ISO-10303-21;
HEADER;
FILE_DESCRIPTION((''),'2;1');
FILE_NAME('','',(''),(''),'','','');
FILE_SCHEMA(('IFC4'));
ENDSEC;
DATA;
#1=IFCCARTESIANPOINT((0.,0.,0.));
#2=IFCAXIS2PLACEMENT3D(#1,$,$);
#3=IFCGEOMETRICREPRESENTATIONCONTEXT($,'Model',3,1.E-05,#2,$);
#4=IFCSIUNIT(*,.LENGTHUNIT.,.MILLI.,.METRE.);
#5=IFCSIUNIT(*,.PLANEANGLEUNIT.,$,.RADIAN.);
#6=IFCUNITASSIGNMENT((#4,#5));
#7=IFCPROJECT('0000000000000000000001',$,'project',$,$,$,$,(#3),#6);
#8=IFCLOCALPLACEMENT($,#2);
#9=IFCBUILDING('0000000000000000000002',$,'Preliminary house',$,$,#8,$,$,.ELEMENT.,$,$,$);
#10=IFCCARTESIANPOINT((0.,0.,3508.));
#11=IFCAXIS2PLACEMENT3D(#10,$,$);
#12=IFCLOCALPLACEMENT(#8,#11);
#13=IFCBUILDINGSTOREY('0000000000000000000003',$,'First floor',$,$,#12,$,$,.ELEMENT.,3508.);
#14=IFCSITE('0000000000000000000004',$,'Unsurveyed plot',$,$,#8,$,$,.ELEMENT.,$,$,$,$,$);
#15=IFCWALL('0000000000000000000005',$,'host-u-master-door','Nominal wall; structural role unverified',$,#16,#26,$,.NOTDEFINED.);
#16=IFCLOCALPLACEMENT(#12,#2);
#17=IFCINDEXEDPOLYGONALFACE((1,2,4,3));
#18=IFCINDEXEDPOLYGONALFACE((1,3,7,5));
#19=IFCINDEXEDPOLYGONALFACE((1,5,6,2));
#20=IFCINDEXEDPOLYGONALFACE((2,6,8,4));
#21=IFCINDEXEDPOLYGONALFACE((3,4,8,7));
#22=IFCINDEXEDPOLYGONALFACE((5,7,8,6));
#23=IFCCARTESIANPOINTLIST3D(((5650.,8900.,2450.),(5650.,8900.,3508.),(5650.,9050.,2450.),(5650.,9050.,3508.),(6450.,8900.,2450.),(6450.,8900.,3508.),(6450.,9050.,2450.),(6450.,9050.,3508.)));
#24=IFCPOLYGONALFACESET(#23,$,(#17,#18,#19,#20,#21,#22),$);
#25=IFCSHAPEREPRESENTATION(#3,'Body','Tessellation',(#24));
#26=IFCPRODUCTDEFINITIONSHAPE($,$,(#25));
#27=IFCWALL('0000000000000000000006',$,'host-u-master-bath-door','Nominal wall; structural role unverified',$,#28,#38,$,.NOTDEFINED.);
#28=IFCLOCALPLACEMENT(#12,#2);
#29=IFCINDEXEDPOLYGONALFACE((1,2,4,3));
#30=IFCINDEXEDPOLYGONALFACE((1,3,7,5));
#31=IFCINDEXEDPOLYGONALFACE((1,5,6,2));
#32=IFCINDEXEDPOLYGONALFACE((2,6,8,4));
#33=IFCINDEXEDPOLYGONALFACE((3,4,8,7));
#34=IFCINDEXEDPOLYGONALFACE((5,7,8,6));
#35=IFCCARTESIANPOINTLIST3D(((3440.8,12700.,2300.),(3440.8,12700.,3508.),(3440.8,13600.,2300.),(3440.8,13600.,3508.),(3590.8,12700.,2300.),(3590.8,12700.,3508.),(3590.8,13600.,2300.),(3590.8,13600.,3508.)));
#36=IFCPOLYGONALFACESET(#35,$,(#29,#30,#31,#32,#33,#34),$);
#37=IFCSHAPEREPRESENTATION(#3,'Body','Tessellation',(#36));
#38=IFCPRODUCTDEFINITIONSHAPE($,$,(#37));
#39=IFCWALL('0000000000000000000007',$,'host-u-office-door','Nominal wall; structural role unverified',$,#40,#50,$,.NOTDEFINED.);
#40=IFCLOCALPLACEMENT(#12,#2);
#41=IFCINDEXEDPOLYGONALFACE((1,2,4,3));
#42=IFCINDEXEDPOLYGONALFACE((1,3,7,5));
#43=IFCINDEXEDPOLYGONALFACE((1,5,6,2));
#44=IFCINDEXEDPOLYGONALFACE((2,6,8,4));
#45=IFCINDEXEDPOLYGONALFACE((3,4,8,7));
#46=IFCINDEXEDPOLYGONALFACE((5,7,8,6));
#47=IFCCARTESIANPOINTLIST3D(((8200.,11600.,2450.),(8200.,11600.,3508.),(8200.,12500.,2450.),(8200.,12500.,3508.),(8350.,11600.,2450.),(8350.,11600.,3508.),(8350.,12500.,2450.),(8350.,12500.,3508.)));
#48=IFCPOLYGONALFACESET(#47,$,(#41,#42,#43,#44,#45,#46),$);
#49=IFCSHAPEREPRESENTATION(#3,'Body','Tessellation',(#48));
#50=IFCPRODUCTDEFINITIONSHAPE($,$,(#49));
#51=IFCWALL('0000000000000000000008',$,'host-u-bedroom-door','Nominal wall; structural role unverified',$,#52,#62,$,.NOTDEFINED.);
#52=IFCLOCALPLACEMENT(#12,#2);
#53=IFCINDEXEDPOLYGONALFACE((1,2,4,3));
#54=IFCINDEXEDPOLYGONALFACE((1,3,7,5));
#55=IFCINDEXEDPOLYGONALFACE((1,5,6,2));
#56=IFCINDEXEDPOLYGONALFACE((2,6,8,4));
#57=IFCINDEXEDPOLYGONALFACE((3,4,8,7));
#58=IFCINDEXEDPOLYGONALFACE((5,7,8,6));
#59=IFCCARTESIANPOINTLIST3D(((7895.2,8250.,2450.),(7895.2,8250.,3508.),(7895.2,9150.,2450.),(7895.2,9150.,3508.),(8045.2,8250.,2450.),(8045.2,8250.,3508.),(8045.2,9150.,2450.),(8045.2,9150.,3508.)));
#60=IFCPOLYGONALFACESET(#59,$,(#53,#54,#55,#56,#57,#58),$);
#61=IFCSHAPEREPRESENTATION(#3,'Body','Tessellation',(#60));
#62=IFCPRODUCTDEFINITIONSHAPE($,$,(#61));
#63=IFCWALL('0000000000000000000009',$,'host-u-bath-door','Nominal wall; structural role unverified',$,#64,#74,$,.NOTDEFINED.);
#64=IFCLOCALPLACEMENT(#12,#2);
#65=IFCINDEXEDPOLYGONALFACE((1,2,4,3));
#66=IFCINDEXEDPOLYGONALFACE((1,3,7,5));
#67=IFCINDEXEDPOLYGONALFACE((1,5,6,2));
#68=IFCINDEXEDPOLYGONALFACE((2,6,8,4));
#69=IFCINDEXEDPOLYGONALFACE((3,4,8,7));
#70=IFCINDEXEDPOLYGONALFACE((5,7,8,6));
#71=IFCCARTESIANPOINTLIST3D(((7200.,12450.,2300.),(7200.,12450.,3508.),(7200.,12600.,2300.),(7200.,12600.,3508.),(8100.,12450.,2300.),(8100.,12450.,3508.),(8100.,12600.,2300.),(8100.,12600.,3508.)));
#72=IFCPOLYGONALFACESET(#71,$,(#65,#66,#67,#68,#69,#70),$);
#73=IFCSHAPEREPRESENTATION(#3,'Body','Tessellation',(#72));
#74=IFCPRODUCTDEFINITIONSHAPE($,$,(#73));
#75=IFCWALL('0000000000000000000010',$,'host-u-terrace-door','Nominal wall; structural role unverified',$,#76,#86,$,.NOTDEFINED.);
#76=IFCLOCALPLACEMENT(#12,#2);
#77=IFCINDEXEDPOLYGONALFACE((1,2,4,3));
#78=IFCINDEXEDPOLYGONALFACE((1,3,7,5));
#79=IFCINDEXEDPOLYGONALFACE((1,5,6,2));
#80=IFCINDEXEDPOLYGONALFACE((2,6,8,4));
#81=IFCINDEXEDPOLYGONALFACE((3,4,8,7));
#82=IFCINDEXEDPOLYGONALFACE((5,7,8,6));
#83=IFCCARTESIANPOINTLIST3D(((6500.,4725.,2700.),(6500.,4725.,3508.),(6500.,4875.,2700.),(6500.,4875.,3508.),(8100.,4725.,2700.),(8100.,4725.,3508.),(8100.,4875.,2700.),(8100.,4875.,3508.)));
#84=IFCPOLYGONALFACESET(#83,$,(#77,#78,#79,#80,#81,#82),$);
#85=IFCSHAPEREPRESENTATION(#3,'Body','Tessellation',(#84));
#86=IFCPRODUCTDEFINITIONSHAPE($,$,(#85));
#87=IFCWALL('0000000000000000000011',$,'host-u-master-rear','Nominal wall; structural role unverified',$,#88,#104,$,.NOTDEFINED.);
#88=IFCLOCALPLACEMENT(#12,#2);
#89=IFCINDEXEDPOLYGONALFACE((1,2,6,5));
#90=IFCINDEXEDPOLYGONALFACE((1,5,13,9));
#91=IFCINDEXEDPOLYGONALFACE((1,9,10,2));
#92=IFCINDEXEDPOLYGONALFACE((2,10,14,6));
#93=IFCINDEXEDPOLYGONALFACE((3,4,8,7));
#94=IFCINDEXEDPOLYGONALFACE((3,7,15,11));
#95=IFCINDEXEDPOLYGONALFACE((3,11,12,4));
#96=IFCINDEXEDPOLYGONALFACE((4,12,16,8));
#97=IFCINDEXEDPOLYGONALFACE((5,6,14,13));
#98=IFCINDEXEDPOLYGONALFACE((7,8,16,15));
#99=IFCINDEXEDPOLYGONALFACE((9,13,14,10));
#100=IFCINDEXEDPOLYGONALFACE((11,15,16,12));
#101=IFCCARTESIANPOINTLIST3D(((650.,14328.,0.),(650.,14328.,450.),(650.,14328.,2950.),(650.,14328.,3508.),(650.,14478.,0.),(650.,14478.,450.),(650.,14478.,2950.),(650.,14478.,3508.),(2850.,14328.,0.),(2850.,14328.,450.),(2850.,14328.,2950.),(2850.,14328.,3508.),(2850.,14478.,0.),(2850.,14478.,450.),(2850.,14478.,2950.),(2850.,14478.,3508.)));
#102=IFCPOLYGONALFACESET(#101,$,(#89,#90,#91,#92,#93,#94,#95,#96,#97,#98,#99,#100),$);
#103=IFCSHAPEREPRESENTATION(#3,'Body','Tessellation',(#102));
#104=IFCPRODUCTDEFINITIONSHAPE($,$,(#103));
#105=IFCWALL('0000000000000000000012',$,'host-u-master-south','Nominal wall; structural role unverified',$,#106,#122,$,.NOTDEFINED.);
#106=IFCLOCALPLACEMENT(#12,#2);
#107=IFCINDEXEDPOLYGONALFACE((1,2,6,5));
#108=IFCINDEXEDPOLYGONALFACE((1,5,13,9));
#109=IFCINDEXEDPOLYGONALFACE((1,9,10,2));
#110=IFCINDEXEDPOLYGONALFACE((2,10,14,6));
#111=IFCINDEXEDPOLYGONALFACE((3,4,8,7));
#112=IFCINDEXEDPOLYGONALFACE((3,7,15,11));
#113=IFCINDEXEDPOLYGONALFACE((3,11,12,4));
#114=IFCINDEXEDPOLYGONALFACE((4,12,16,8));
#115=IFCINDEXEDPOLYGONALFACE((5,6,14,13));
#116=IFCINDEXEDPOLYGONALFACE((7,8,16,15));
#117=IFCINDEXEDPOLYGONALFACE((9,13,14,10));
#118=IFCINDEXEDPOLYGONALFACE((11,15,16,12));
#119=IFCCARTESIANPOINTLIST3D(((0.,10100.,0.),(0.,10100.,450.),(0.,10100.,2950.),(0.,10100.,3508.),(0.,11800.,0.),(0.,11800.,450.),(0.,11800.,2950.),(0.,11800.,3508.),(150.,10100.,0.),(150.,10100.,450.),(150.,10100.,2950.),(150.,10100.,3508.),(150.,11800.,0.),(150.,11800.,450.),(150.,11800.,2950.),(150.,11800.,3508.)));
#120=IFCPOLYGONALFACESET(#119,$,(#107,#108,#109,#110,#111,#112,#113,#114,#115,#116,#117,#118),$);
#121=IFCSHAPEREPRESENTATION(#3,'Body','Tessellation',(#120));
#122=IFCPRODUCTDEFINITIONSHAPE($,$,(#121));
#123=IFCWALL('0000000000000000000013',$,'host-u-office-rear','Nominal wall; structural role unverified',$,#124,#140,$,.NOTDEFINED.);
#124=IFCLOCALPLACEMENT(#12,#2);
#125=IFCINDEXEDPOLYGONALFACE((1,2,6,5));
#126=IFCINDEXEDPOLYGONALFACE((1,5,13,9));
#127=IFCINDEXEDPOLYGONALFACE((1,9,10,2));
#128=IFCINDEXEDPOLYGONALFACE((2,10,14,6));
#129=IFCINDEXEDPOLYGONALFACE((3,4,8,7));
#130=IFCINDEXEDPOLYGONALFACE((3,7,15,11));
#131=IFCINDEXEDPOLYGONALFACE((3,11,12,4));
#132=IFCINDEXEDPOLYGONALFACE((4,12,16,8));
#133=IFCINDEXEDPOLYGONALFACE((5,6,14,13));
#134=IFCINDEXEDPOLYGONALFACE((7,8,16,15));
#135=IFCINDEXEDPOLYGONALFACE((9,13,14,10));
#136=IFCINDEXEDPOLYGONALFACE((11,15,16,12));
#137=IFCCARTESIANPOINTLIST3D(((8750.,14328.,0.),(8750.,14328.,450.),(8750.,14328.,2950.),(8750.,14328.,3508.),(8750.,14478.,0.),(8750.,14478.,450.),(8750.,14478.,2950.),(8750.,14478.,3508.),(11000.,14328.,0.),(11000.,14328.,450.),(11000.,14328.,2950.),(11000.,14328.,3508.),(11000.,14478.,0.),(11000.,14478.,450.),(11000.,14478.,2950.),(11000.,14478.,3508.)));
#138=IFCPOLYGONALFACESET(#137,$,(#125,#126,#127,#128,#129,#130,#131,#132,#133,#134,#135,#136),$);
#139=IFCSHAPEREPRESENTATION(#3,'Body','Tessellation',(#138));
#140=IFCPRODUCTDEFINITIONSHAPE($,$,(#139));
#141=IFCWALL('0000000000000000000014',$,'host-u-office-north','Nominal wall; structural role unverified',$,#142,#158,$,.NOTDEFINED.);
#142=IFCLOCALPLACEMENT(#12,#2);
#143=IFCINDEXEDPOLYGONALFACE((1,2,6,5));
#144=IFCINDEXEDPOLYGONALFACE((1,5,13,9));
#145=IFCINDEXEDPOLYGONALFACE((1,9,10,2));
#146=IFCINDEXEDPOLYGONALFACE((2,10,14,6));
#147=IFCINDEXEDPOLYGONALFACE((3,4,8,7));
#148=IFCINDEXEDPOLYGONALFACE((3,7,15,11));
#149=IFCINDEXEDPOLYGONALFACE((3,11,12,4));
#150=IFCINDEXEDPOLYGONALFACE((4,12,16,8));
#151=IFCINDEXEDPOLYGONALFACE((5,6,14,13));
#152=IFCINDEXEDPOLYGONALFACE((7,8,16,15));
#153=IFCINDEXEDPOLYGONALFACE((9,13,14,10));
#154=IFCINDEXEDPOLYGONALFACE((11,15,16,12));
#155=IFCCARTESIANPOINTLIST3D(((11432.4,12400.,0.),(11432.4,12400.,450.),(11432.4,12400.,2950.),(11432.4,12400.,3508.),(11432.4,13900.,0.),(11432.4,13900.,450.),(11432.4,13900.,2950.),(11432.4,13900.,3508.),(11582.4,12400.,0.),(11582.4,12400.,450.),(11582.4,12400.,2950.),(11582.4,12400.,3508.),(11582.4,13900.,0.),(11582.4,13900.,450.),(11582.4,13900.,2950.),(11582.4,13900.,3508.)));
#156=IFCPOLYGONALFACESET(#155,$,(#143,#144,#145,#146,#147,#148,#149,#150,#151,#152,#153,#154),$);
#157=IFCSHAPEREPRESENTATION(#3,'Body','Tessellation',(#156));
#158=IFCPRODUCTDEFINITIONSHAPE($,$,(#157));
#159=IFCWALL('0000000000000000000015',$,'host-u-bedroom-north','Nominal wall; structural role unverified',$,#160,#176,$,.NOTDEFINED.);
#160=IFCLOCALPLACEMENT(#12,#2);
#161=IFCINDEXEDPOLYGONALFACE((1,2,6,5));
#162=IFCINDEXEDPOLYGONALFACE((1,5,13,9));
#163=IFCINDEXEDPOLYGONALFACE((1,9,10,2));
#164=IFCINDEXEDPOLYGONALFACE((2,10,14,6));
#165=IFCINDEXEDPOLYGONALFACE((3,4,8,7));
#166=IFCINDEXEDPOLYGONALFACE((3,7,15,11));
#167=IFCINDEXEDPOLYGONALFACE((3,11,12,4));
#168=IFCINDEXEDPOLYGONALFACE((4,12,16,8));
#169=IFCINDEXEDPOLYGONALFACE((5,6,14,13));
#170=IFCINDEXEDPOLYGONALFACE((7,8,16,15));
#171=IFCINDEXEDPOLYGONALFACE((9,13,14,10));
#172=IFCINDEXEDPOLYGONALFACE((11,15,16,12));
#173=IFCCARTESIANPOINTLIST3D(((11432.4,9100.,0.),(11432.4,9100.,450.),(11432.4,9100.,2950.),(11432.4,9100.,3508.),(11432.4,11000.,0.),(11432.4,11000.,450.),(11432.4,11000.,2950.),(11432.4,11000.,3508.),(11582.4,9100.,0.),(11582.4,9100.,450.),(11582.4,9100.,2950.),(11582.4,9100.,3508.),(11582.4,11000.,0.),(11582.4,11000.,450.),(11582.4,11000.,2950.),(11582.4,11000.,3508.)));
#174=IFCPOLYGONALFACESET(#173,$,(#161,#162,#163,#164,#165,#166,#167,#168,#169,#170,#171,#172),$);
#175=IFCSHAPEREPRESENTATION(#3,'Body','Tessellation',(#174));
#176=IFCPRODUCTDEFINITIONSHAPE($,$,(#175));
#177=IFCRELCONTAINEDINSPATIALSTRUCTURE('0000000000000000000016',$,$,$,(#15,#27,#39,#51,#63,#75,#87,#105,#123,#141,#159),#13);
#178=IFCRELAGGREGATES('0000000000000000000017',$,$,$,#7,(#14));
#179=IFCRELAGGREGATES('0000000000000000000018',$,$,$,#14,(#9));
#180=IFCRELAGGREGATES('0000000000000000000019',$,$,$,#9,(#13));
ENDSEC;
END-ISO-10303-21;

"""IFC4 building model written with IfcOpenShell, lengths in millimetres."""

from ifc_helpers import new_model, si_unit, frame, origin, place, context, project, spatial, polyline, outline, extrude, element, save


model = new_model("IFC4")

# Units and contexts
model_context = context("Model", 3, precision=1e-05, world=origin())
ifc_project = project(units=[si_unit("LENGTHUNIT", "METRE", prefix="MILLI"), si_unit("PLANEANGLEUNIT", "RADIAN")], contexts=[model_context])

# Site, building, storey
placement_1 = place(None, origin())
site = spatial("IfcSite", under=ifc_project, at=placement_1, Name="Unsurveyed plot", CompositionType="ELEMENT")
building = spatial("IfcBuilding", under=site, at=placement_1, Name="Preliminary house", CompositionType="ELEMENT")
placement_2 = place(placement_1, frame((0.0, 0.0, 3508.0)))
storey = spatial("IfcBuildingStorey", under=building, at=placement_2, Name="First floor", CompositionType="ELEMENT", Elevation=3508.0)

# Walls, openings
wall_1 = element("IfcWall", 1, at=placement_2, inside=storey, Name="host-u-master-door", Description="Nominal wall; structural role unverified", PredefinedType="NOTDEFINED", context=model_context, shape_type="SweptSolid", body=[
    extrude(outline(polyline([(6450.0, 9050.0), (6450.0, 8900.0), (5650.0, 8900.0), (5650.0, 9050.0), (6450.0, 9050.0)])), origin(), (0.0, 0.0, 1.0), 3508.0),
])
element("IfcOpeningElement", 2, at=placement_2, cuts=wall_1, PredefinedType="OPENING", context=model_context, shape_type="SweptSolid", body=[
    extrude(outline(polyline([(5650.0, 8525.0), (6450.0, 8525.0), (6450.0, 9425.0), (5650.0, 9425.0), (5650.0, 8525.0)])), origin(), (0.0, 0.0, 1.0), 2450.0),
])
wall_2 = element("IfcWall", 3, at=placement_2, inside=storey, Name="host-u-master-bath-door", Description="Nominal wall; structural role unverified", PredefinedType="NOTDEFINED", context=model_context, shape_type="SweptSolid", body=[
    extrude(outline(polyline([(3440.8, 13600.0), (3590.8, 13600.0), (3590.8, 12700.0), (3440.8, 12700.0), (3440.8, 13600.0)])), origin(), (0.0, 0.0, 1.0), 3508.0),
])
element("IfcOpeningElement", 4, at=placement_2, cuts=wall_2, PredefinedType="OPENING", context=model_context, shape_type="SweptSolid", body=[
    extrude(outline(polyline([(3965.8, 12700.0), (3965.8, 13600.0), (3065.8, 13600.0), (3065.8, 12700.0), (3965.8, 12700.0)])), origin(), (0.0, 0.0, 1.0), 2300.0),
])
wall_3 = element("IfcWall", 5, at=placement_2, inside=storey, Name="host-u-office-door", Description="Nominal wall; structural role unverified", PredefinedType="NOTDEFINED", context=model_context, shape_type="SweptSolid", body=[
    extrude(outline(polyline([(8200.0, 12500.0), (8350.0, 12500.0), (8350.0, 11600.0), (8200.0, 11600.0), (8200.0, 12500.0)])), origin(), (0.0, 0.0, 1.0), 3508.0),
])
element("IfcOpeningElement", 6, at=placement_2, cuts=wall_3, PredefinedType="OPENING", context=model_context, shape_type="SweptSolid", body=[
    extrude(outline(polyline([(8725.0, 11600.0), (8725.0, 12500.0), (7825.0, 12500.0), (7825.0, 11600.0), (8725.0, 11600.0)])), origin(), (0.0, 0.0, 1.0), 2450.0),
])
wall_4 = element("IfcWall", 7, at=placement_2, inside=storey, Name="host-u-bedroom-door", Description="Nominal wall; structural role unverified", PredefinedType="NOTDEFINED", context=model_context, shape_type="SweptSolid", body=[
    extrude(outline(polyline([(7895.2, 9150.0), (8045.2, 9150.0), (8045.2, 8250.0), (7895.2, 8250.0), (7895.2, 9150.0)])), origin(), (0.0, 0.0, 1.0), 3508.0),
])
element("IfcOpeningElement", 8, at=placement_2, cuts=wall_4, PredefinedType="OPENING", context=model_context, shape_type="SweptSolid", body=[
    extrude(outline(polyline([(8420.2, 8250.0), (8420.2, 9150.0), (7520.2, 9150.0), (7520.2, 8250.0), (8420.2, 8250.0)])), origin(), (0.0, 0.0, 1.0), 2450.0),
])
wall_5 = element("IfcWall", 9, at=placement_2, inside=storey, Name="host-u-bath-door", Description="Nominal wall; structural role unverified", PredefinedType="NOTDEFINED", context=model_context, shape_type="SweptSolid", body=[
    extrude(outline(polyline([(8100.0, 12600.0), (8100.0, 12450.0), (7200.0, 12450.0), (7200.0, 12600.0), (8100.0, 12600.0)])), origin(), (0.0, 0.0, 1.0), 3508.0),
])
element("IfcOpeningElement", 10, at=placement_2, cuts=wall_5, PredefinedType="OPENING", context=model_context, shape_type="SweptSolid", body=[
    extrude(outline(polyline([(7200.0, 12075.0), (8100.0, 12075.0), (8100.0, 12975.0), (7200.0, 12975.0), (7200.0, 12075.0)])), origin(), (0.0, 0.0, 1.0), 2300.0),
])
wall_6 = element("IfcWall", 11, at=placement_2, inside=storey, Name="host-u-terrace-door", Description="Nominal wall; structural role unverified", PredefinedType="NOTDEFINED", context=model_context, shape_type="SweptSolid", body=[
    extrude(outline(polyline([(8100.0, 4875.0), (8100.0, 4725.0), (6500.0, 4725.0), (6500.0, 4875.0), (8100.0, 4875.0)])), origin(), (0.0, 0.0, 1.0), 3508.0),
])
element("IfcOpeningElement", 12, at=placement_2, cuts=wall_6, PredefinedType="OPENING", context=model_context, shape_type="SweptSolid", body=[
    extrude(outline(polyline([(6500.0, 4350.0), (8100.0, 4350.0), (8100.0, 5250.0), (6500.0, 5250.0), (6500.0, 4350.0)])), origin(), (0.0, 0.0, 1.0), 2700.0),
])
wall_7 = element("IfcWall", 13, at=placement_2, inside=storey, Name="host-u-master-rear", Description="Nominal wall; structural role unverified", PredefinedType="NOTDEFINED", context=model_context, shape_type="SweptSolid", body=[
    extrude(outline(polyline([(2850.0, 14478.0), (2850.0, 14328.0), (650.0, 14328.0), (650.0, 14478.0), (2850.0, 14478.0)])), origin(), (0.0, 0.0, 1.0), 3508.0),
])
element("IfcOpeningElement", 14, at=placement_2, cuts=wall_7, PredefinedType="OPENING", context=model_context, shape_type="SweptSolid", body=[
    extrude(outline(polyline([(650.0, 13953.0), (2850.0, 13953.0), (2850.0, 14853.0), (650.0, 14853.0), (650.0, 13953.0)])), frame((0.0, 0.0, 450.0)), (0.0, 0.0, 1.0), 2500.0),
])
wall_8 = element("IfcWall", 15, at=placement_2, inside=storey, Name="host-u-master-south", Description="Nominal wall; structural role unverified", PredefinedType="NOTDEFINED", context=model_context, shape_type="SweptSolid", body=[
    extrude(outline(polyline([(0.0, 11800.0), (150.0, 11800.0), (150.0, 10100.0), (0.0, 10100.0), (0.0, 11800.0)])), origin(), (0.0, 0.0, 1.0), 3508.0),
])
element("IfcOpeningElement", 16, at=placement_2, cuts=wall_8, PredefinedType="OPENING", context=model_context, shape_type="SweptSolid", body=[
    extrude(outline(polyline([(525.0, 10100.0), (525.0, 11800.0), (-375.0, 11800.0), (-375.0, 10100.0), (525.0, 10100.0)])), frame((0.0, 0.0, 450.0)), (0.0, 0.0, 1.0), 2500.0),
])
wall_9 = element("IfcWall", 17, at=placement_2, inside=storey, Name="host-u-office-rear", Description="Nominal wall; structural role unverified", PredefinedType="NOTDEFINED", context=model_context, shape_type="SweptSolid", body=[
    extrude(outline(polyline([(11000.0, 14478.0), (11000.0, 14328.0), (8750.0, 14328.0), (8750.0, 14478.0), (11000.0, 14478.0)])), origin(), (0.0, 0.0, 1.0), 3508.0),
])
element("IfcOpeningElement", 18, at=placement_2, cuts=wall_9, PredefinedType="OPENING", context=model_context, shape_type="SweptSolid", body=[
    extrude(outline(polyline([(8750.0, 13953.0), (11000.0, 13953.0), (11000.0, 14853.0), (8750.0, 14853.0), (8750.0, 13953.0)])), frame((0.0, 0.0, 450.0)), (0.0, 0.0, 1.0), 2500.0),
])
wall_10 = element("IfcWall", 19, at=placement_2, inside=storey, Name="host-u-office-north", Description="Nominal wall; structural role unverified", PredefinedType="NOTDEFINED", context=model_context, shape_type="SweptSolid", body=[
    extrude(outline(polyline([(11432.4, 13900.0), (11582.4, 13900.0), (11582.4, 12400.0), (11432.4, 12400.0), (11432.4, 13900.0)])), origin(), (0.0, 0.0, 1.0), 3508.0),
])
element("IfcOpeningElement", 20, at=placement_2, cuts=wall_10, PredefinedType="OPENING", context=model_context, shape_type="SweptSolid", body=[
    extrude(outline(polyline([(11957.4, 12400.0), (11957.4, 13900.0), (11057.4, 13900.0), (11057.4, 12400.0), (11957.4, 12400.0)])), frame((0.0, 0.0, 450.0)), (0.0, 0.0, 1.0), 2500.0),
])
wall_11 = element("IfcWall", 21, at=placement_2, inside=storey, Name="host-u-bedroom-north", Description="Nominal wall; structural role unverified", PredefinedType="NOTDEFINED", context=model_context, shape_type="SweptSolid", body=[
    extrude(outline(polyline([(11432.4, 11000.0), (11582.4, 11000.0), (11582.4, 9100.0), (11432.4, 9100.0), (11432.4, 11000.0)])), origin(), (0.0, 0.0, 1.0), 3508.0),
])
element("IfcOpeningElement", 22, at=placement_2, cuts=wall_11, PredefinedType="OPENING", context=model_context, shape_type="SweptSolid", body=[
    extrude(outline(polyline([(11957.4, 9100.0), (11957.4, 11000.0), (11057.4, 11000.0), (11057.4, 9100.0), (11957.4, 9100.0)])), frame((0.0, 0.0, 450.0)), (0.0, 0.0, 1.0), 2500.0),
])

save(model, "model.ifc")
